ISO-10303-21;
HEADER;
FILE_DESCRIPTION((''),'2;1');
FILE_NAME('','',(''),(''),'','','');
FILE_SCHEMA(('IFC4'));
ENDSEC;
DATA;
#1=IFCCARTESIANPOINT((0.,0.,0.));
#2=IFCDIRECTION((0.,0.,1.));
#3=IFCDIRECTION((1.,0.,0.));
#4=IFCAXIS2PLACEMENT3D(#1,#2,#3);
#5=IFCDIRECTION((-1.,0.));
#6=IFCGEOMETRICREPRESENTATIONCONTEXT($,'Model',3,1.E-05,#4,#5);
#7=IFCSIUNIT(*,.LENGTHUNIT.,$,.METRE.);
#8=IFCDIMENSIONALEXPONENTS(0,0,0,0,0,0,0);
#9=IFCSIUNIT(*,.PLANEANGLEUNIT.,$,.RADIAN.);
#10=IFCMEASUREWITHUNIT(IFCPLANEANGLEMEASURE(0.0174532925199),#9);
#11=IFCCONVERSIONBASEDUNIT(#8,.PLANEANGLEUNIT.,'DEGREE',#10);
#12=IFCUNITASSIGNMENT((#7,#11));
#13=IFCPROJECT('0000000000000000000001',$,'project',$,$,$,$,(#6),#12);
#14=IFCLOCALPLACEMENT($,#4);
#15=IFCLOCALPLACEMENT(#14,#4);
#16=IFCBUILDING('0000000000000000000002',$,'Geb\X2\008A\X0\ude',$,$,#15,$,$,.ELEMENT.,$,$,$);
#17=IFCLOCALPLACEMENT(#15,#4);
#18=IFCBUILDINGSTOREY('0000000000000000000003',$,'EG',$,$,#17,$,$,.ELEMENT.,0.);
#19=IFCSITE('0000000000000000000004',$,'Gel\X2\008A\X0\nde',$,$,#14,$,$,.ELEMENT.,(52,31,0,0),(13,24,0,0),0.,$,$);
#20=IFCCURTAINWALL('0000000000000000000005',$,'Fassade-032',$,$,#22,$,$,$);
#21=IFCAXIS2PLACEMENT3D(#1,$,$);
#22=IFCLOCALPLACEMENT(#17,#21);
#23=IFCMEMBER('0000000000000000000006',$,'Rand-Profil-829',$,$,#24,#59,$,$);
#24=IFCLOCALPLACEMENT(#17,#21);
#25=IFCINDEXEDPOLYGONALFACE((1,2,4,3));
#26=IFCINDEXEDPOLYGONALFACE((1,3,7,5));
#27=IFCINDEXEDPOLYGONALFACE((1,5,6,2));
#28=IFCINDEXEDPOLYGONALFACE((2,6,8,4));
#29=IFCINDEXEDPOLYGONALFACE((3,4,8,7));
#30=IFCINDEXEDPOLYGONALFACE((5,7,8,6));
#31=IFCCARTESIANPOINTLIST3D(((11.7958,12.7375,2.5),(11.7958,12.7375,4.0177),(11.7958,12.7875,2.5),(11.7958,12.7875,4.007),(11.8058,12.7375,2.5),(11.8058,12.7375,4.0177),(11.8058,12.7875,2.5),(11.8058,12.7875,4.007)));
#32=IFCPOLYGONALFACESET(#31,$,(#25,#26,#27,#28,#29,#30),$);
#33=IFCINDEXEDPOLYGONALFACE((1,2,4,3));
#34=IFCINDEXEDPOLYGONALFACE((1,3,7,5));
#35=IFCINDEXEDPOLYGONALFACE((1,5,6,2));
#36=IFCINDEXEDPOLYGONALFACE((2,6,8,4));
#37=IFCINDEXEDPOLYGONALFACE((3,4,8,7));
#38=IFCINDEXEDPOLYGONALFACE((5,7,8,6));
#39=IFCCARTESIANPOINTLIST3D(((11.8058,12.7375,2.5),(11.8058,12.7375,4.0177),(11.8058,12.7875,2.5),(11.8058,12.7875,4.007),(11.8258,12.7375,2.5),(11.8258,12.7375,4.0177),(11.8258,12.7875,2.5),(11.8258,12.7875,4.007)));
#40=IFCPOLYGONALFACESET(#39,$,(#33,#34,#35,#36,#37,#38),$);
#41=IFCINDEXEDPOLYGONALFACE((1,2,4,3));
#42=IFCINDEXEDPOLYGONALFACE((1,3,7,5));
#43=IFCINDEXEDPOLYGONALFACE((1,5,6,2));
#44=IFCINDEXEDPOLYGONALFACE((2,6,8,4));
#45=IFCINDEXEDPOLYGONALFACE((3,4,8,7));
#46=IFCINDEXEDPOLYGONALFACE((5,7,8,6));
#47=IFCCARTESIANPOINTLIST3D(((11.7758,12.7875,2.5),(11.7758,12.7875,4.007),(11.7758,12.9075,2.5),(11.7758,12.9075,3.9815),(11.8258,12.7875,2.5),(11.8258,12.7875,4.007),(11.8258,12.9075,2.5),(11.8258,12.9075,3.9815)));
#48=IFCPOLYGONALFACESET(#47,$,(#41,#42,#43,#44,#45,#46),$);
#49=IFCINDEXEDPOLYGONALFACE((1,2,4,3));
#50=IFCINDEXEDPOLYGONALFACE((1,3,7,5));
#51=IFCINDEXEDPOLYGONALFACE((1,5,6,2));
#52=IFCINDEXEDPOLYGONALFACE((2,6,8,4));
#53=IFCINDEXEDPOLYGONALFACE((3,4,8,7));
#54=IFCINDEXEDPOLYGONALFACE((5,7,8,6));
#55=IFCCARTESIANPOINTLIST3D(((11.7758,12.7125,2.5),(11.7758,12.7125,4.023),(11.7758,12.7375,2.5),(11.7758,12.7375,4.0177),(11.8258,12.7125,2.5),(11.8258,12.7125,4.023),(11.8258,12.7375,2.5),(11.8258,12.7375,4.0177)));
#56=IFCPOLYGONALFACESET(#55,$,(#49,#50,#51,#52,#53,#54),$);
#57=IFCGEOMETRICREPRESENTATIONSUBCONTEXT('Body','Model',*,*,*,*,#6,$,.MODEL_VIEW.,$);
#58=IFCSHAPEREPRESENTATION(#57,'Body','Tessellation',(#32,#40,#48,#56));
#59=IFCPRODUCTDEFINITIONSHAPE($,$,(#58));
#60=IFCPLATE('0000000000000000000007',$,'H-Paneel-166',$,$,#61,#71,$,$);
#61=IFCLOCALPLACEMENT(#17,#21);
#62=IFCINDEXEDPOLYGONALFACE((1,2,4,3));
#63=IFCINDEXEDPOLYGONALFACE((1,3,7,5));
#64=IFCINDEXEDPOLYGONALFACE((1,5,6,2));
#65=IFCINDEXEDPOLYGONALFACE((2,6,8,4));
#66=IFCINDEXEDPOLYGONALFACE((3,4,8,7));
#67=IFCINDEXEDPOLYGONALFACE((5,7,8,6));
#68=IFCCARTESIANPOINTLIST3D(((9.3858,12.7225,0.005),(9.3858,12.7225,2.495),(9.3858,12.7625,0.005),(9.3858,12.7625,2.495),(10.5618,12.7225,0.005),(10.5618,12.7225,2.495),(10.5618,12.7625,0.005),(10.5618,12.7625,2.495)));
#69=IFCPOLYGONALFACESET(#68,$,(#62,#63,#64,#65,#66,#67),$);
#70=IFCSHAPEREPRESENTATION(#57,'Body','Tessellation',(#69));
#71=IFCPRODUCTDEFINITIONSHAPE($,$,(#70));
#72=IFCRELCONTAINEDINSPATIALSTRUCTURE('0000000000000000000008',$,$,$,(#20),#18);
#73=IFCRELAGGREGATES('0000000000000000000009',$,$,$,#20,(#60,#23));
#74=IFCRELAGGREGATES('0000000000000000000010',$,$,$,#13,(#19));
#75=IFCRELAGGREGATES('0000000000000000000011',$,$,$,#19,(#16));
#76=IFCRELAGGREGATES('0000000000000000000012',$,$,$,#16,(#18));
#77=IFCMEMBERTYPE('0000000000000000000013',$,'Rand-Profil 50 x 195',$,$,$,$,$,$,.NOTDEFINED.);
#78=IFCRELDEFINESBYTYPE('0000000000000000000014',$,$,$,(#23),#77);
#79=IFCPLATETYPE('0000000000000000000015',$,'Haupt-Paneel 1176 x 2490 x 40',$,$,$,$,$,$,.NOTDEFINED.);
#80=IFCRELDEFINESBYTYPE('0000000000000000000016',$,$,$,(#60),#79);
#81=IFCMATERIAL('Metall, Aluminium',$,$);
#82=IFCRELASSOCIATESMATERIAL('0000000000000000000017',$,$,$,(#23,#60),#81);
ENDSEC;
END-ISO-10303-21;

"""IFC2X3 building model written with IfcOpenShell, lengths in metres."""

from ifc_helpers import new_model, entity, si_unit, converted_unit, direction, frame, origin_with_axes, place, context, subcontext, project, spatial, polyline, outline, extrude, clip, halfspace, material, type_object, element, aggregate, save


model = new_model("IFC2X3")

# Units and contexts
model_context = context("Model", 3, precision=1e-05, world=origin_with_axes(), true_north=direction((-1.0, 0.0)))
body_context = subcontext(model_context, "Body", "Model", "MODEL_VIEW")
ifc_project = project(units=[si_unit("LENGTHUNIT", "METRE"), converted_unit("PLANEANGLEUNIT", "DEGREE", entity("IfcPlaneAngleMeasure", 0.0174532925199), si_unit("PLANEANGLEUNIT", "RADIAN"), dimensions=[0, 0, 0, 0, 0, 0, 0])], contexts=[model_context])

# Site, building, storey
site_placement = place(None, origin_with_axes())
site = spatial("IfcSite", under=ifc_project, at=site_placement, Name="Gel\u008ande", CompositionType="ELEMENT", RefLatitude=(52, 31, 0, 0), RefLongitude=(13, 24, 0, 0), RefElevation=0.0)
building_placement = place(site_placement, origin_with_axes())
building = spatial("IfcBuilding", under=site, at=building_placement, Name="Geb\u008aude", CompositionType="ELEMENT")
storey_placement = place(building_placement, origin_with_axes())
storey = spatial("IfcBuildingStorey", under=building, at=storey_placement, Name="EG", CompositionType="ELEMENT", Elevation=0.0)

# Curtain wall
curtain_wall_1_placement = place(storey_placement, frame((9.9738, 12.7625, 0.0), z_axis=(0.0, 0.0, 1.0), x_axis=(1.0, 0.0, 0.0)))
curtain_wall_1 = element("IfcCurtainWall", 1, at=curtain_wall_1_placement, inside=storey, Name="Fassade-032")
ifc_material = material(Name="Metall, Aluminium")

# Member
member_type_1 = type_object("IfcMemberType", Name="Rand-Profil 50 x 195", PredefinedType="NOTDEFINED")
member_1_placement = place(curtain_wall_1_placement, frame((1.827, 0.0, 2.5), z_axis=(0.0, 0.0, 1.0), x_axis=(-1.0, 0.0, 0.0)))
member_1 = element("IfcMember", 2, at=member_1_placement, type_object=member_type_1, material=ifc_material, Name="Rand-Profil-829", context=body_context, shape_type="Clipping", body=[
    clip(extrude(outline(polyline([(0.005, 0.025), (-0.005, 0.025), (-0.005, -0.025), (0.005, -0.025), (0.005, 0.025)])), frame((0.0, 0.0, 0.0), z_axis=(0.0, 0.0, 1.0), x_axis=(-1.0, 0.0, 0.0)), (0.0, 0.0, 1.0), 1.5177), halfspace(frame((0.0, -0.3076, 1.447), z_axis=(0.0, 0.207912, -0.978148), x_axis=(0.0, -0.978148, -0.207912)), True)),
    clip(extrude(outline(polyline([(0.025, 0.025), (0.005, 0.025), (0.005, -0.025), (0.025, -0.025), (0.025, 0.025)])), frame((0.0, 0.0, 0.0), z_axis=(0.0, 0.0, 1.0), x_axis=(-1.0, 0.0, 0.0)), (0.0, 0.0, 1.0), 1.5177), halfspace(frame((0.0, -0.3076, 1.447), z_axis=(0.0, 0.207912, -0.978148), x_axis=(0.0, -0.978148, -0.207912)), True)),
    clip(extrude(outline(polyline([(0.025, 0.145), (-0.025, 0.145), (-0.025, 0.025), (0.025, 0.025), (0.025, 0.145)])), frame((0.0, 0.0, 0.0), z_axis=(0.0, 0.0, 1.0), x_axis=(-1.0, 0.0, 0.0)), (0.0, 0.0, 1.0), 1.507), halfspace(frame((0.0, -0.3076, 1.447), z_axis=(0.0, 0.207912, -0.978148), x_axis=(0.0, -0.978148, -0.207912)), True)),
    clip(extrude(outline(polyline([(0.025, -0.025), (-0.025, -0.025), (-0.025, -0.05), (0.025, -0.05), (0.025, -0.025)])), frame((0.0, 0.0, 0.0), z_axis=(0.0, 0.0, 1.0), x_axis=(-1.0, 0.0, 0.0)), (0.0, 0.0, 1.0), 1.523), halfspace(frame((0.0, -0.3076, 1.447), z_axis=(0.0, 0.207912, -0.978148), x_axis=(0.0, -0.978148, -0.207912)), True)),
])

# Plate
plate_type_1 = type_object("IfcPlateType", Name="Haupt-Paneel 1176 x 2490 x 40", PredefinedType="NOTDEFINED")
plate_1_placement = place(curtain_wall_1_placement, frame((0.0, 0.0, 1.25), z_axis=(0.0, 0.0, 1.0), x_axis=(-1.0, 0.0, 0.0)))
plate_1 = element("IfcPlate", 3, at=plate_1_placement, type_object=plate_type_1, material=ifc_material, Name="H-Paneel-166", context=body_context, shape_type="SweptSolid", body=[
    extrude(outline(polyline([(0.005, 0.005), (1.181, 0.005), (1.181, 2.495), (0.005, 2.495), (0.005, 0.005)])), frame((0.593, 0.0, -1.25), z_axis=(0.0, 1.0, 0.0), x_axis=(-1.0, 0.0, 0.0)), (0.0, 0.0, 1.0), 0.04),
])
aggregate(curtain_wall_1, [plate_1, member_1])

save(model, "model.ifc")
